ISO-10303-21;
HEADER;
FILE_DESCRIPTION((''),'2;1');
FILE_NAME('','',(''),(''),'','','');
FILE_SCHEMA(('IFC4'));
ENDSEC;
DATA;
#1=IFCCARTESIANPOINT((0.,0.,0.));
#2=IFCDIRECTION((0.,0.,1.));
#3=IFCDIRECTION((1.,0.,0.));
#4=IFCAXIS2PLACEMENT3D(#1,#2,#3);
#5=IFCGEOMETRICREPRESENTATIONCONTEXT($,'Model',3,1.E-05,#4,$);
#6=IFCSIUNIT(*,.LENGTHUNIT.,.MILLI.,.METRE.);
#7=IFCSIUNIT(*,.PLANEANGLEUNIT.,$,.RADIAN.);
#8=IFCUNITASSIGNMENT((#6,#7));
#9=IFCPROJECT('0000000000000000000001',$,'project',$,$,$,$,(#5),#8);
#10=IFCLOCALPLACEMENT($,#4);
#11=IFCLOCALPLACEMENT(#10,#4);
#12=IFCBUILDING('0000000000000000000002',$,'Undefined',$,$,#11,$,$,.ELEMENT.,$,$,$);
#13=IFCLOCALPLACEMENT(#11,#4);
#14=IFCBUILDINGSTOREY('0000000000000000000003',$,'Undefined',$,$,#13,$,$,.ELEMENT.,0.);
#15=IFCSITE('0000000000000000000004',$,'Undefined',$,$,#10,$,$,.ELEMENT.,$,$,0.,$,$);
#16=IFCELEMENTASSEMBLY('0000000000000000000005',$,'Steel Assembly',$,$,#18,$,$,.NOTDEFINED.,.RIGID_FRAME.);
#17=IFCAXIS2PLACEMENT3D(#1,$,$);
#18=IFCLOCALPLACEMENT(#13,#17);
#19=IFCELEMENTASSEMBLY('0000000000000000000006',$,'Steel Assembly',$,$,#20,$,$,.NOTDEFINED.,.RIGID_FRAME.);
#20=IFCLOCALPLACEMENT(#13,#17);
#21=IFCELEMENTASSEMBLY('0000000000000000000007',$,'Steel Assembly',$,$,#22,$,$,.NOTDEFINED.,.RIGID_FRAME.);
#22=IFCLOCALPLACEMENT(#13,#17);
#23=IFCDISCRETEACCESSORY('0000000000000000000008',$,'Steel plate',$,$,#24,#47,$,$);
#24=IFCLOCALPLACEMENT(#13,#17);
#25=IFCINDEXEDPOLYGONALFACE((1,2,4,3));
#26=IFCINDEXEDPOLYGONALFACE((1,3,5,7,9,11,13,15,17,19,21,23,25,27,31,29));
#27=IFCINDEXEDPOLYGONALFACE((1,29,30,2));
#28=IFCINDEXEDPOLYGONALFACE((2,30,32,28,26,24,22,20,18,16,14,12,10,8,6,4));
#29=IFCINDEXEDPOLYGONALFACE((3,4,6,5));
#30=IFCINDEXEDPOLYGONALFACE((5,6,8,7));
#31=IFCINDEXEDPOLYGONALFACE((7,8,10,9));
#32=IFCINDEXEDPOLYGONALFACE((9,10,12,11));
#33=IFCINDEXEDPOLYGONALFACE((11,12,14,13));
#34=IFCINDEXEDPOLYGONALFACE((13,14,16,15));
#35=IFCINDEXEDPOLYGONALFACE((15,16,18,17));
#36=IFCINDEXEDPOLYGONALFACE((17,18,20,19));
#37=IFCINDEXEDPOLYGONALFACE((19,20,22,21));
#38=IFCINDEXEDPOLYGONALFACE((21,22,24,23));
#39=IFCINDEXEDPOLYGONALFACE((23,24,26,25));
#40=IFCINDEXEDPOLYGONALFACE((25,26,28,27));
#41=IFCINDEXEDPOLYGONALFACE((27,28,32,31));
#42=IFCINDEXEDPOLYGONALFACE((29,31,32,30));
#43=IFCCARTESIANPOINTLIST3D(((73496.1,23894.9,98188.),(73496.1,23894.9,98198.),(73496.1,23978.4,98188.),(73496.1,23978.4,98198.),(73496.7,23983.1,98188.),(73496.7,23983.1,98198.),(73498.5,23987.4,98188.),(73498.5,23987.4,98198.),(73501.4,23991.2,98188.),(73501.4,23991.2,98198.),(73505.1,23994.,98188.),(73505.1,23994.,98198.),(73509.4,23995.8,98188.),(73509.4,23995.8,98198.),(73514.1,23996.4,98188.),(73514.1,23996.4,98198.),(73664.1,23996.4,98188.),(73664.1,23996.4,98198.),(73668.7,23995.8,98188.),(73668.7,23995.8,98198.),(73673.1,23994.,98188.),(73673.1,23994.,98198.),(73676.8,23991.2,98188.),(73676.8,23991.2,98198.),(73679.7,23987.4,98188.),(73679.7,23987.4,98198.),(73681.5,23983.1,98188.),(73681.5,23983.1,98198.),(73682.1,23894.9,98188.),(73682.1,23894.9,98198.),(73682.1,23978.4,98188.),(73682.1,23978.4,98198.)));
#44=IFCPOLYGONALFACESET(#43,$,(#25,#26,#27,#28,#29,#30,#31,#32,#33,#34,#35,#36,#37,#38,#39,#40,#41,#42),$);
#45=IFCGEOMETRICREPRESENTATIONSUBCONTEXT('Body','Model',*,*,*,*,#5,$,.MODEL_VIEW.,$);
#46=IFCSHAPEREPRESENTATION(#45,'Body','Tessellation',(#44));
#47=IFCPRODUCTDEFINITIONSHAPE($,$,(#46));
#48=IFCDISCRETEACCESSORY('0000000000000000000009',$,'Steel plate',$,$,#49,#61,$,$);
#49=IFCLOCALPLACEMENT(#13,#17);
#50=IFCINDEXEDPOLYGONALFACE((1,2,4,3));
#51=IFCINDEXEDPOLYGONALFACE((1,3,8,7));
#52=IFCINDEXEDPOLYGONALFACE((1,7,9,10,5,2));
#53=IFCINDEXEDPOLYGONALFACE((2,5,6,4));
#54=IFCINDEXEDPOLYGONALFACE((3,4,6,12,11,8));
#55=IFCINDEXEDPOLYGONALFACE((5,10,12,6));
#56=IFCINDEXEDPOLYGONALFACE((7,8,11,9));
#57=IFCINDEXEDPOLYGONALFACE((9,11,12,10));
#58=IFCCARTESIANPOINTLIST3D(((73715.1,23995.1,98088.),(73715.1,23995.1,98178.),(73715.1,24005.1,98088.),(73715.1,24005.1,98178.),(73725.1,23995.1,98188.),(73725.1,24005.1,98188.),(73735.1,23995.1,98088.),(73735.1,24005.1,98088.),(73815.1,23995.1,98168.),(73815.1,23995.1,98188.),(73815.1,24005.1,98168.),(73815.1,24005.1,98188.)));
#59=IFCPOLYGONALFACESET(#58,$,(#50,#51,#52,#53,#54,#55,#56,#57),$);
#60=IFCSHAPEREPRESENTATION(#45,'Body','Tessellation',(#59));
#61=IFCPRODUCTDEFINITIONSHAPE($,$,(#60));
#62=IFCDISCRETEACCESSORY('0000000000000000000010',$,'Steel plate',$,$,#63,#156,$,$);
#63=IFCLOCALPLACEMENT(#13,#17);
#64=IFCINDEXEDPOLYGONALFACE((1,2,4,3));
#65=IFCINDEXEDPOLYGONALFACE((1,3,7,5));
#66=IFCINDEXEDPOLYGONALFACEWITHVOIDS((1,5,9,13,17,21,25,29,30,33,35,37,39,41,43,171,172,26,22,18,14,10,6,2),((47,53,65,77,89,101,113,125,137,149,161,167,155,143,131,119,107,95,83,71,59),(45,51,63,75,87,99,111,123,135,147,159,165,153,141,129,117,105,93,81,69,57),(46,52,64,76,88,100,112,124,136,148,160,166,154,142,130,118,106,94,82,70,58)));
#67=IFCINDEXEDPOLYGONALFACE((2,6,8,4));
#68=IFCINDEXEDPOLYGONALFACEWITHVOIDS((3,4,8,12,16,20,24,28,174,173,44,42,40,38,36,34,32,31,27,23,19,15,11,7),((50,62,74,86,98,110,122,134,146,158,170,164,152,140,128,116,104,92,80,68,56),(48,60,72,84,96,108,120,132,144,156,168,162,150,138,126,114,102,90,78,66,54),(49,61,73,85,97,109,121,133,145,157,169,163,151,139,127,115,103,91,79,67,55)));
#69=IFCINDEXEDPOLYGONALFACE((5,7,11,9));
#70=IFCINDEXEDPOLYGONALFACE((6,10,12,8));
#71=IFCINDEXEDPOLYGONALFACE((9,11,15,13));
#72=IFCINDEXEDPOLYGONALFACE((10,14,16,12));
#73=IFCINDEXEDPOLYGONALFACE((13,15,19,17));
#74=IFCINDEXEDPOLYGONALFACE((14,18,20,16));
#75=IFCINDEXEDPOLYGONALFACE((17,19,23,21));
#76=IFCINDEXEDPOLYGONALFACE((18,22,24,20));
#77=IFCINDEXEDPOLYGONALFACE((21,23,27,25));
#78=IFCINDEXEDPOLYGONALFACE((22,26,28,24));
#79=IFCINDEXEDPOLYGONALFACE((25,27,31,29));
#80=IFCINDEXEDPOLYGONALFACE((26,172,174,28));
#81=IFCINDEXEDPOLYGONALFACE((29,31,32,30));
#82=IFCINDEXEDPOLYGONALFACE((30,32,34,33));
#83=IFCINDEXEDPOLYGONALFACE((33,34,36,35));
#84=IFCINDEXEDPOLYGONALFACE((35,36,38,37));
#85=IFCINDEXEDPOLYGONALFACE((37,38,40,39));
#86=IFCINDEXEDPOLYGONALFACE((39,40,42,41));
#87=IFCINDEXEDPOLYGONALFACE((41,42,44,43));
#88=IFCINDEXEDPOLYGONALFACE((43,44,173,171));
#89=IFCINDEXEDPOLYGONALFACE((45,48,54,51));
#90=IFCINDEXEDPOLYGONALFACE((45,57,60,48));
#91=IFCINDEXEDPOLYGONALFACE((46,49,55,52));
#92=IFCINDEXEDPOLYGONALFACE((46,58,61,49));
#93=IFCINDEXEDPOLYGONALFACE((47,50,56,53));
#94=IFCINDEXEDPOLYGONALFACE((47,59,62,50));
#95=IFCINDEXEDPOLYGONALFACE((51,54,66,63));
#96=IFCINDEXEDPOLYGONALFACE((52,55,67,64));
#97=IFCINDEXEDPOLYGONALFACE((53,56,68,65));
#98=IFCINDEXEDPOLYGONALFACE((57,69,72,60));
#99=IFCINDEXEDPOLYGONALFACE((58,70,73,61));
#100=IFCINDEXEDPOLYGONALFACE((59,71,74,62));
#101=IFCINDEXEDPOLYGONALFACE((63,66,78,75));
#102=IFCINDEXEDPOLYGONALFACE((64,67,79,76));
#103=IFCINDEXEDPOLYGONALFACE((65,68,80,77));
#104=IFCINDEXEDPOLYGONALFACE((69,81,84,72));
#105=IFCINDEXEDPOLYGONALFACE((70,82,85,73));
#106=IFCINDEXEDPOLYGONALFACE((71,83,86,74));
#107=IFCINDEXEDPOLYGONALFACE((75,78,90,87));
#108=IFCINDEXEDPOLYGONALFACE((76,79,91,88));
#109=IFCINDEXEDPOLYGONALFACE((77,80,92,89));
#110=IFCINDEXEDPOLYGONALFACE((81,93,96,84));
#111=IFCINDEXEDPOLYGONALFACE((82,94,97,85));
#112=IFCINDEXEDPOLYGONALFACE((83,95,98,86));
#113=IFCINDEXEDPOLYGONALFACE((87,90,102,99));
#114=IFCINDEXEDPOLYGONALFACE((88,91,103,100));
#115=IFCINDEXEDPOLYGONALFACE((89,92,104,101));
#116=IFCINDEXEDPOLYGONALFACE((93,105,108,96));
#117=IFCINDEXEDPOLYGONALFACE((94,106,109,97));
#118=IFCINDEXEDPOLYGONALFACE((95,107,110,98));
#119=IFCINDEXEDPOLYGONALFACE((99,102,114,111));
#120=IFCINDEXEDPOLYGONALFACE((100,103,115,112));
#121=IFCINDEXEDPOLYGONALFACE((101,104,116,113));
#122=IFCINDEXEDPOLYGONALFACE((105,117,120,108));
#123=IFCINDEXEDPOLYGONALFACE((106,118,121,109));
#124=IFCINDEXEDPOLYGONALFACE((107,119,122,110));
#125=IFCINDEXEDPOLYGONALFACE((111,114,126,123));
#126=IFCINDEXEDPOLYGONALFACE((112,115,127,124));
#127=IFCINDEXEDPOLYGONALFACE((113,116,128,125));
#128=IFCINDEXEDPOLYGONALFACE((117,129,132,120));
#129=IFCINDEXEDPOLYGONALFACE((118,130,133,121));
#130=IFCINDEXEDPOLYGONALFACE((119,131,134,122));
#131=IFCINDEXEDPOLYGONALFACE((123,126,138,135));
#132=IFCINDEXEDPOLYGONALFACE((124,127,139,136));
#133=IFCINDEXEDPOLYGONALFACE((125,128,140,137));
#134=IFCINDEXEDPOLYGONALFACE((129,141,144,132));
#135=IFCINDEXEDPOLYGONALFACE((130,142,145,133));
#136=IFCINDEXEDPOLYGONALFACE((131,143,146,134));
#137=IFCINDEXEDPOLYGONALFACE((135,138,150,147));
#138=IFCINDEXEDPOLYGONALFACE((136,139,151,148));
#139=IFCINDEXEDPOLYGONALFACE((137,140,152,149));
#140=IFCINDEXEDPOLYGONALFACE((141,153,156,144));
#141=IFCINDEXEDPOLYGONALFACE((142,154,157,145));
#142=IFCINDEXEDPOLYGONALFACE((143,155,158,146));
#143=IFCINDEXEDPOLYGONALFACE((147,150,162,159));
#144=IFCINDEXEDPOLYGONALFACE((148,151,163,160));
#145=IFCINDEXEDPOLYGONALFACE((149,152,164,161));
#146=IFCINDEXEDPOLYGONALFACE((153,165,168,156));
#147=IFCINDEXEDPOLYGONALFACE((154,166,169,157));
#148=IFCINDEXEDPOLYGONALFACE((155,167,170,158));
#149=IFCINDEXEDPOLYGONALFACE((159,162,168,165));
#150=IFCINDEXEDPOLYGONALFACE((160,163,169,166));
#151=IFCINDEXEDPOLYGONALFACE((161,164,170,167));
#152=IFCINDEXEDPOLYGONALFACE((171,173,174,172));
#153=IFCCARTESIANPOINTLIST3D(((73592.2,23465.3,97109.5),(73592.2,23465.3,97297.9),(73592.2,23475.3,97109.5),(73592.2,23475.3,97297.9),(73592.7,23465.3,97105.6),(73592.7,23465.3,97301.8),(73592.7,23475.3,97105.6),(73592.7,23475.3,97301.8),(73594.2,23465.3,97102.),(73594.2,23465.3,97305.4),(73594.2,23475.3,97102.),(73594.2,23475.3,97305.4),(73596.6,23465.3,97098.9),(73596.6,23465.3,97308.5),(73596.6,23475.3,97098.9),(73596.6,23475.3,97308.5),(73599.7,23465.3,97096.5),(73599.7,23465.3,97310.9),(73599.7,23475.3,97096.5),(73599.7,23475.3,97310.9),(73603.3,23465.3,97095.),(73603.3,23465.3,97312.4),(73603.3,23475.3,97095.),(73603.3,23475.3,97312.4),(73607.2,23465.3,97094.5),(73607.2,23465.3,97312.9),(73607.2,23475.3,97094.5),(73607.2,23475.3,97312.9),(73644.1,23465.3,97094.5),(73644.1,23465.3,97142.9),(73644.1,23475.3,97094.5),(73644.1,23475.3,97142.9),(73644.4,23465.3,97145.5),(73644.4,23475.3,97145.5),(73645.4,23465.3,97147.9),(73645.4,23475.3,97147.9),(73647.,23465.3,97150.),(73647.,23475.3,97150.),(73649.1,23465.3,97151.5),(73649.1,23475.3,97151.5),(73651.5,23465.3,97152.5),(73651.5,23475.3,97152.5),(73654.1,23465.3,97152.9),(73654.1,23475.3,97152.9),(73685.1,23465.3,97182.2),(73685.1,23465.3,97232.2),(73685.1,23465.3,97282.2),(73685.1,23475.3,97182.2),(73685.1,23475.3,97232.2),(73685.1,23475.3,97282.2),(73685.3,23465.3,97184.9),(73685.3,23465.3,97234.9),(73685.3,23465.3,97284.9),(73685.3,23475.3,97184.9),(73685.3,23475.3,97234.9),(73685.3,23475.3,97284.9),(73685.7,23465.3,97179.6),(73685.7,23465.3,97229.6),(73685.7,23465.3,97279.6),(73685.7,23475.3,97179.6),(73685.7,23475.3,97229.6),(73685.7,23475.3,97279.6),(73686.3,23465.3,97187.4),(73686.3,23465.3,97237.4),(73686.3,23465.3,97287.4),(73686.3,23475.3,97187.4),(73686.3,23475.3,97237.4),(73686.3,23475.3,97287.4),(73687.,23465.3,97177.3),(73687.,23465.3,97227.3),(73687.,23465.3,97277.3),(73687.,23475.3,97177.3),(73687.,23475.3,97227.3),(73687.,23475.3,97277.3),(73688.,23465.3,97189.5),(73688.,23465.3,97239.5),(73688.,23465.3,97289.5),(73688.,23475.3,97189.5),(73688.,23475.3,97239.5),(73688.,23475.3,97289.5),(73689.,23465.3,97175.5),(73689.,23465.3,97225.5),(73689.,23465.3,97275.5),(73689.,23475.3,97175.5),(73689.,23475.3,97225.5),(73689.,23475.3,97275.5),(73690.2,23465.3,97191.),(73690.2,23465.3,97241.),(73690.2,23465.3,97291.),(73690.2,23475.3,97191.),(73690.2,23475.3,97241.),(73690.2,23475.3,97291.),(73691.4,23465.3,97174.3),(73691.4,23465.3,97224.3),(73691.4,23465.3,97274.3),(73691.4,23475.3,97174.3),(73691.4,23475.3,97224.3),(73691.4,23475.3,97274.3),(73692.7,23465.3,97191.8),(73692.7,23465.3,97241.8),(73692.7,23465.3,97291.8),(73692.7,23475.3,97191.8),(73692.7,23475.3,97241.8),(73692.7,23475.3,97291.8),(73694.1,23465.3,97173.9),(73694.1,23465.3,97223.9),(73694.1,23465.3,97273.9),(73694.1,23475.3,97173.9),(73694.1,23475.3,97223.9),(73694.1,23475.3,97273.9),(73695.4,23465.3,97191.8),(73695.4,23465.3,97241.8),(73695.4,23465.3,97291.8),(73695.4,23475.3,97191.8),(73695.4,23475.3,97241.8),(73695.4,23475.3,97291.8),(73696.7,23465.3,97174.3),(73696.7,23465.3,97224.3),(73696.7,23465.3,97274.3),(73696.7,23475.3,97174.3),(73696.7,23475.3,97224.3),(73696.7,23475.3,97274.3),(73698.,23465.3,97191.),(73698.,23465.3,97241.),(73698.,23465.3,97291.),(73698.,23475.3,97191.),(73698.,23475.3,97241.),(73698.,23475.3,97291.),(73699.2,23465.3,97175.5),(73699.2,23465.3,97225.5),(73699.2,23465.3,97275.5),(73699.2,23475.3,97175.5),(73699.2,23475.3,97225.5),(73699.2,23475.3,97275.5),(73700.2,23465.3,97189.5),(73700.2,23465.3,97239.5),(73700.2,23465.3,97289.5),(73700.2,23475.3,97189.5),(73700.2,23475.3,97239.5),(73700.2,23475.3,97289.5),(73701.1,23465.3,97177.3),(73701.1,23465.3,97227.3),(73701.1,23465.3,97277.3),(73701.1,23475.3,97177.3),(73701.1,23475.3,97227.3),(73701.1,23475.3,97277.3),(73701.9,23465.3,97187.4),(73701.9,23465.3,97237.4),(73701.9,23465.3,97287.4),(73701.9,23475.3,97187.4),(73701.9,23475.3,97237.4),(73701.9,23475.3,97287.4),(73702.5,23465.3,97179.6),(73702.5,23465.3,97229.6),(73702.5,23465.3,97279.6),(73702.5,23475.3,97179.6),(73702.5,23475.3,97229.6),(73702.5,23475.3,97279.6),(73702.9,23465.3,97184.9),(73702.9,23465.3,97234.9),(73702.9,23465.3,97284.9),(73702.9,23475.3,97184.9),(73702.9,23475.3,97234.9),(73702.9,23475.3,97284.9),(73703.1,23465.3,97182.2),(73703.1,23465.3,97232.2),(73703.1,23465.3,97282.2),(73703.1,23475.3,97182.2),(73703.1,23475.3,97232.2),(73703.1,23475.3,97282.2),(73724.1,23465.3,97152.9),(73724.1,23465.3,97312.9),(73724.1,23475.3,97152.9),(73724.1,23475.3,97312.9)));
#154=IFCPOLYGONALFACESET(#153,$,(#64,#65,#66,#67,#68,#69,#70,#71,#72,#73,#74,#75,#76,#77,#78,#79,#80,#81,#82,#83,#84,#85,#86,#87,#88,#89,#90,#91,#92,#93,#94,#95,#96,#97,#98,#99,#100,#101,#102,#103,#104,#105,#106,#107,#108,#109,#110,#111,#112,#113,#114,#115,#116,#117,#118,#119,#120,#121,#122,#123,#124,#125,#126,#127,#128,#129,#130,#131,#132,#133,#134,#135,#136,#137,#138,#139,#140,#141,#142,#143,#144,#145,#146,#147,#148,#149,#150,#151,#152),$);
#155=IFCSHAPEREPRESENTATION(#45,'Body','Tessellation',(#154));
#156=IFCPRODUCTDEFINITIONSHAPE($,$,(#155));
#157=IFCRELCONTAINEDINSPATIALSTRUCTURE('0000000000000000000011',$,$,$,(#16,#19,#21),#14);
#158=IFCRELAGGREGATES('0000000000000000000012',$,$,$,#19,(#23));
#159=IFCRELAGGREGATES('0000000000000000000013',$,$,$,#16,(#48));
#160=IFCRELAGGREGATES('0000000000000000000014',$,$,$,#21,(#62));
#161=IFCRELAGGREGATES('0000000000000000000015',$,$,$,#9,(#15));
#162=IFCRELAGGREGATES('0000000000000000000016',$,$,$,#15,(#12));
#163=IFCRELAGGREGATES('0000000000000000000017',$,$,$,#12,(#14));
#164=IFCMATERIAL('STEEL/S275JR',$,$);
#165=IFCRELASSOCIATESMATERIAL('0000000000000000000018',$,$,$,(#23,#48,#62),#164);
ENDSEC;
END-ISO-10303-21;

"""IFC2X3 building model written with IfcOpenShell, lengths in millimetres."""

from ifc_helpers import new_model, si_unit, frame, frame_2d, origin_with_axes, origin_2d_with_axis, place, context, subcontext, project, spatial, polyline, circle_curve, parameter, trimmed, segment, composite_curve, circle, outline, extrude, source, transform, mapped, material, element, aggregate, save


model = new_model("IFC2X3")

# Units and contexts
model_context = context("Model", 3, precision=1e-05, world=origin_with_axes())
body_context = subcontext(model_context, "Body", "Model", "MODEL_VIEW")
ifc_project = project(units=[si_unit("LENGTHUNIT", "METRE", prefix="MILLI"), si_unit("PLANEANGLEUNIT", "RADIAN")], contexts=[model_context])

# Site, building, storey
site_placement = place(None, origin_with_axes())
site = spatial("IfcSite", under=ifc_project, at=site_placement, Name="Undefined", CompositionType="ELEMENT", RefElevation=0.0)
building_placement = place(site_placement, origin_with_axes())
building = spatial("IfcBuilding", under=site, at=building_placement, Name="Undefined", CompositionType="ELEMENT")
storey_placement = place(building_placement, origin_with_axes())
storey = spatial("IfcBuildingStorey", under=building, at=storey_placement, Name="Undefined", CompositionType="ELEMENT", Elevation=0.0)

# Element assembly
assembly_1_placement = place(storey_placement, origin_with_axes())
assembly_1 = element("IfcElementAssembly", 1, at=assembly_1_placement, inside=storey, Name="Steel Assembly", AssemblyPlace="NOTDEFINED", PredefinedType="RIGID_FRAME")

# Element assembly
assembly_2_placement = place(storey_placement, origin_with_axes())
assembly_2 = element("IfcElementAssembly", 2, at=assembly_2_placement, inside=storey, Name="Steel Assembly", AssemblyPlace="NOTDEFINED", PredefinedType="RIGID_FRAME")

# Element assembly
assembly_3_placement = place(storey_placement, origin_with_axes())
assembly_3 = element("IfcElementAssembly", 3, at=assembly_3_placement, inside=storey, Name="Steel Assembly", AssemblyPlace="NOTDEFINED", PredefinedType="RIGID_FRAME")
ifc_material_1 = material(Name="STEEL/S275JR")

# Discrete accessories
discrete_accessory_1_placement = place(assembly_2_placement, frame((73496.1, 23894.9, 98193.0), z_axis=(0.0, 0.0, 1.0), x_axis=(1.0, 0.0, 0.0)))
discrete_accessory_1 = element("IfcDiscreteAccessory", 4, at=discrete_accessory_1_placement, material=ifc_material_1, Name="Steel plate", context=body_context, shape_type="SweptSolid", body=[
    extrude(outline(composite_curve([segment(polyline([(0.0, 0.0), (186.0, 0.0), (186.0, 83.5)]), True, "CONTINUOUS"), segment(trimmed(circle_curve(frame_2d((168.0, 83.5), x_axis=(1.0, 0.0)), 18.0), [parameter(0.0)], [parameter(1.570796)], True, "PARAMETER"), True, "CONTINUOUS"), segment(polyline([(168.0, 101.5), (18.0, 101.5)]), True, "CONTINUOUS"), segment(trimmed(circle_curve(frame_2d((18.0, 83.5), x_axis=(0.0, 1.0)), 18.0), [parameter(0.0)], [parameter(1.570796)], True, "PARAMETER"), True, "CONTINUOUS"), segment(polyline([(0.0, 83.5), (0.0, 0.0)]), True, "DISCONTINUOUS")], self_intersect=False)), frame((0.0, 0.0, -5.0), z_axis=(0.0, 0.0, 1.0), x_axis=(1.0, 0.0, 0.0)), (0.0, 0.0, 1.0), 10.0),
])
aggregate(assembly_2, [discrete_accessory_1])
discrete_accessory_2_placement = place(assembly_1_placement, frame((73715.1, 24000.1, 98088.0), z_axis=(0.0, 1.0, 0.0), x_axis=(0.0, 0.0, 1.0)))
discrete_accessory_2 = element("IfcDiscreteAccessory", 5, at=discrete_accessory_2_placement, material=ifc_material_1, Name="Steel plate", context=body_context, shape_type="SweptSolid", body=[
    extrude(outline(polyline([(0.0, 0.0), (90.0, 0.0), (100.0, 10.0), (100.0, 100.0), (80.0, 100.0), (0.0, 20.0), (0.0, 0.0)])), frame((0.0, 0.0, -5.0), z_axis=(0.0, 0.0, 1.0), x_axis=(1.0, 0.0, 0.0)), (0.0, 0.0, 1.0), 10.0),
])
aggregate(assembly_1, [discrete_accessory_2])

# Discrete accessory, opening
discrete_accessory_3_placement = place(assembly_3_placement, frame((73592.2, 23470.3, 97312.9), z_axis=(0.0, 1.0, 0.0), x_axis=(1.0, 0.0, 0.0)))
discrete_accessory_3 = element("IfcDiscreteAccessory", 6, at=discrete_accessory_3_placement, material=ifc_material_1, Name="Steel plate", context=body_context, shape_type="SweptSolid", body=[
    extrude(outline(composite_curve([segment(trimmed(circle_curve(frame_2d((15.0, 15.0), x_axis=(-1.0, 0.0)), 15.0), [parameter(0.0)], [parameter(1.570796)], True, "PARAMETER"), True, "CONTINUOUS"), segment(polyline([(15.0, 0.0), (131.9, 0.0), (131.9, 160.0), (61.9, 160.0)]), True, "CONTINUOUS"), segment(trimmed(circle_curve(frame_2d((61.9, 170.0), x_axis=(0.0, -1.0)), 10.0), [parameter(0.0)], [parameter(4.712389)], False, "PARAMETER"), True, "CONTINUOUS"), segment(polyline([(51.9, 170.0), (51.9, 218.4), (15.0, 218.4)]), True, "CONTINUOUS"), segment(trimmed(circle_curve(frame_2d((15.0, 203.4), x_axis=(0.0, 1.0)), 15.0), [parameter(0.0)], [parameter(1.570796)], True, "PARAMETER"), True, "CONTINUOUS"), segment(polyline([(0.0, 203.4), (0.0, 15.0)]), True, "DISCONTINUOUS")], self_intersect=False)), frame((0.0, 0.0, -5.0), z_axis=(0.0, 0.0, 1.0), x_axis=(1.0, 0.0, 0.0)), (0.0, 0.0, 1.0), 10.0),
])
shared_shape_1 = source(origin_with_axes(), body_context, "Body", "SweptSolid", [
    extrude(circle(Radius=9.0, at=origin_2d_with_axis()), frame((0.0, -0.1, 0.0), z_axis=(0.0, 1.0, 0.0), x_axis=(1.0, 0.0, 0.0)), (0.0, 0.0, 1.0), 10.2),
])
opening_1_placement = place(assembly_3_placement, frame((73694.1, 23475.3, 97282.9), z_axis=(-1.0, 0.0, 0.0), x_axis=(0.0, 0.0, -1.0)))
element("IfcOpeningElement", 7, at=opening_1_placement, cuts=discrete_accessory_3, ObjectType="Opening", context=body_context, shape_type="MappedRepresentation", body=[
    mapped(shared_shape_1, transform((0.0, 0.0, 0.0))),
    mapped(shared_shape_1, transform((50.0, 0.0, 0.0))),
    mapped(shared_shape_1, transform((100.0, 0.0, 0.0))),
])
aggregate(assembly_3, [discrete_accessory_3])

save(model, "model.ifc")
